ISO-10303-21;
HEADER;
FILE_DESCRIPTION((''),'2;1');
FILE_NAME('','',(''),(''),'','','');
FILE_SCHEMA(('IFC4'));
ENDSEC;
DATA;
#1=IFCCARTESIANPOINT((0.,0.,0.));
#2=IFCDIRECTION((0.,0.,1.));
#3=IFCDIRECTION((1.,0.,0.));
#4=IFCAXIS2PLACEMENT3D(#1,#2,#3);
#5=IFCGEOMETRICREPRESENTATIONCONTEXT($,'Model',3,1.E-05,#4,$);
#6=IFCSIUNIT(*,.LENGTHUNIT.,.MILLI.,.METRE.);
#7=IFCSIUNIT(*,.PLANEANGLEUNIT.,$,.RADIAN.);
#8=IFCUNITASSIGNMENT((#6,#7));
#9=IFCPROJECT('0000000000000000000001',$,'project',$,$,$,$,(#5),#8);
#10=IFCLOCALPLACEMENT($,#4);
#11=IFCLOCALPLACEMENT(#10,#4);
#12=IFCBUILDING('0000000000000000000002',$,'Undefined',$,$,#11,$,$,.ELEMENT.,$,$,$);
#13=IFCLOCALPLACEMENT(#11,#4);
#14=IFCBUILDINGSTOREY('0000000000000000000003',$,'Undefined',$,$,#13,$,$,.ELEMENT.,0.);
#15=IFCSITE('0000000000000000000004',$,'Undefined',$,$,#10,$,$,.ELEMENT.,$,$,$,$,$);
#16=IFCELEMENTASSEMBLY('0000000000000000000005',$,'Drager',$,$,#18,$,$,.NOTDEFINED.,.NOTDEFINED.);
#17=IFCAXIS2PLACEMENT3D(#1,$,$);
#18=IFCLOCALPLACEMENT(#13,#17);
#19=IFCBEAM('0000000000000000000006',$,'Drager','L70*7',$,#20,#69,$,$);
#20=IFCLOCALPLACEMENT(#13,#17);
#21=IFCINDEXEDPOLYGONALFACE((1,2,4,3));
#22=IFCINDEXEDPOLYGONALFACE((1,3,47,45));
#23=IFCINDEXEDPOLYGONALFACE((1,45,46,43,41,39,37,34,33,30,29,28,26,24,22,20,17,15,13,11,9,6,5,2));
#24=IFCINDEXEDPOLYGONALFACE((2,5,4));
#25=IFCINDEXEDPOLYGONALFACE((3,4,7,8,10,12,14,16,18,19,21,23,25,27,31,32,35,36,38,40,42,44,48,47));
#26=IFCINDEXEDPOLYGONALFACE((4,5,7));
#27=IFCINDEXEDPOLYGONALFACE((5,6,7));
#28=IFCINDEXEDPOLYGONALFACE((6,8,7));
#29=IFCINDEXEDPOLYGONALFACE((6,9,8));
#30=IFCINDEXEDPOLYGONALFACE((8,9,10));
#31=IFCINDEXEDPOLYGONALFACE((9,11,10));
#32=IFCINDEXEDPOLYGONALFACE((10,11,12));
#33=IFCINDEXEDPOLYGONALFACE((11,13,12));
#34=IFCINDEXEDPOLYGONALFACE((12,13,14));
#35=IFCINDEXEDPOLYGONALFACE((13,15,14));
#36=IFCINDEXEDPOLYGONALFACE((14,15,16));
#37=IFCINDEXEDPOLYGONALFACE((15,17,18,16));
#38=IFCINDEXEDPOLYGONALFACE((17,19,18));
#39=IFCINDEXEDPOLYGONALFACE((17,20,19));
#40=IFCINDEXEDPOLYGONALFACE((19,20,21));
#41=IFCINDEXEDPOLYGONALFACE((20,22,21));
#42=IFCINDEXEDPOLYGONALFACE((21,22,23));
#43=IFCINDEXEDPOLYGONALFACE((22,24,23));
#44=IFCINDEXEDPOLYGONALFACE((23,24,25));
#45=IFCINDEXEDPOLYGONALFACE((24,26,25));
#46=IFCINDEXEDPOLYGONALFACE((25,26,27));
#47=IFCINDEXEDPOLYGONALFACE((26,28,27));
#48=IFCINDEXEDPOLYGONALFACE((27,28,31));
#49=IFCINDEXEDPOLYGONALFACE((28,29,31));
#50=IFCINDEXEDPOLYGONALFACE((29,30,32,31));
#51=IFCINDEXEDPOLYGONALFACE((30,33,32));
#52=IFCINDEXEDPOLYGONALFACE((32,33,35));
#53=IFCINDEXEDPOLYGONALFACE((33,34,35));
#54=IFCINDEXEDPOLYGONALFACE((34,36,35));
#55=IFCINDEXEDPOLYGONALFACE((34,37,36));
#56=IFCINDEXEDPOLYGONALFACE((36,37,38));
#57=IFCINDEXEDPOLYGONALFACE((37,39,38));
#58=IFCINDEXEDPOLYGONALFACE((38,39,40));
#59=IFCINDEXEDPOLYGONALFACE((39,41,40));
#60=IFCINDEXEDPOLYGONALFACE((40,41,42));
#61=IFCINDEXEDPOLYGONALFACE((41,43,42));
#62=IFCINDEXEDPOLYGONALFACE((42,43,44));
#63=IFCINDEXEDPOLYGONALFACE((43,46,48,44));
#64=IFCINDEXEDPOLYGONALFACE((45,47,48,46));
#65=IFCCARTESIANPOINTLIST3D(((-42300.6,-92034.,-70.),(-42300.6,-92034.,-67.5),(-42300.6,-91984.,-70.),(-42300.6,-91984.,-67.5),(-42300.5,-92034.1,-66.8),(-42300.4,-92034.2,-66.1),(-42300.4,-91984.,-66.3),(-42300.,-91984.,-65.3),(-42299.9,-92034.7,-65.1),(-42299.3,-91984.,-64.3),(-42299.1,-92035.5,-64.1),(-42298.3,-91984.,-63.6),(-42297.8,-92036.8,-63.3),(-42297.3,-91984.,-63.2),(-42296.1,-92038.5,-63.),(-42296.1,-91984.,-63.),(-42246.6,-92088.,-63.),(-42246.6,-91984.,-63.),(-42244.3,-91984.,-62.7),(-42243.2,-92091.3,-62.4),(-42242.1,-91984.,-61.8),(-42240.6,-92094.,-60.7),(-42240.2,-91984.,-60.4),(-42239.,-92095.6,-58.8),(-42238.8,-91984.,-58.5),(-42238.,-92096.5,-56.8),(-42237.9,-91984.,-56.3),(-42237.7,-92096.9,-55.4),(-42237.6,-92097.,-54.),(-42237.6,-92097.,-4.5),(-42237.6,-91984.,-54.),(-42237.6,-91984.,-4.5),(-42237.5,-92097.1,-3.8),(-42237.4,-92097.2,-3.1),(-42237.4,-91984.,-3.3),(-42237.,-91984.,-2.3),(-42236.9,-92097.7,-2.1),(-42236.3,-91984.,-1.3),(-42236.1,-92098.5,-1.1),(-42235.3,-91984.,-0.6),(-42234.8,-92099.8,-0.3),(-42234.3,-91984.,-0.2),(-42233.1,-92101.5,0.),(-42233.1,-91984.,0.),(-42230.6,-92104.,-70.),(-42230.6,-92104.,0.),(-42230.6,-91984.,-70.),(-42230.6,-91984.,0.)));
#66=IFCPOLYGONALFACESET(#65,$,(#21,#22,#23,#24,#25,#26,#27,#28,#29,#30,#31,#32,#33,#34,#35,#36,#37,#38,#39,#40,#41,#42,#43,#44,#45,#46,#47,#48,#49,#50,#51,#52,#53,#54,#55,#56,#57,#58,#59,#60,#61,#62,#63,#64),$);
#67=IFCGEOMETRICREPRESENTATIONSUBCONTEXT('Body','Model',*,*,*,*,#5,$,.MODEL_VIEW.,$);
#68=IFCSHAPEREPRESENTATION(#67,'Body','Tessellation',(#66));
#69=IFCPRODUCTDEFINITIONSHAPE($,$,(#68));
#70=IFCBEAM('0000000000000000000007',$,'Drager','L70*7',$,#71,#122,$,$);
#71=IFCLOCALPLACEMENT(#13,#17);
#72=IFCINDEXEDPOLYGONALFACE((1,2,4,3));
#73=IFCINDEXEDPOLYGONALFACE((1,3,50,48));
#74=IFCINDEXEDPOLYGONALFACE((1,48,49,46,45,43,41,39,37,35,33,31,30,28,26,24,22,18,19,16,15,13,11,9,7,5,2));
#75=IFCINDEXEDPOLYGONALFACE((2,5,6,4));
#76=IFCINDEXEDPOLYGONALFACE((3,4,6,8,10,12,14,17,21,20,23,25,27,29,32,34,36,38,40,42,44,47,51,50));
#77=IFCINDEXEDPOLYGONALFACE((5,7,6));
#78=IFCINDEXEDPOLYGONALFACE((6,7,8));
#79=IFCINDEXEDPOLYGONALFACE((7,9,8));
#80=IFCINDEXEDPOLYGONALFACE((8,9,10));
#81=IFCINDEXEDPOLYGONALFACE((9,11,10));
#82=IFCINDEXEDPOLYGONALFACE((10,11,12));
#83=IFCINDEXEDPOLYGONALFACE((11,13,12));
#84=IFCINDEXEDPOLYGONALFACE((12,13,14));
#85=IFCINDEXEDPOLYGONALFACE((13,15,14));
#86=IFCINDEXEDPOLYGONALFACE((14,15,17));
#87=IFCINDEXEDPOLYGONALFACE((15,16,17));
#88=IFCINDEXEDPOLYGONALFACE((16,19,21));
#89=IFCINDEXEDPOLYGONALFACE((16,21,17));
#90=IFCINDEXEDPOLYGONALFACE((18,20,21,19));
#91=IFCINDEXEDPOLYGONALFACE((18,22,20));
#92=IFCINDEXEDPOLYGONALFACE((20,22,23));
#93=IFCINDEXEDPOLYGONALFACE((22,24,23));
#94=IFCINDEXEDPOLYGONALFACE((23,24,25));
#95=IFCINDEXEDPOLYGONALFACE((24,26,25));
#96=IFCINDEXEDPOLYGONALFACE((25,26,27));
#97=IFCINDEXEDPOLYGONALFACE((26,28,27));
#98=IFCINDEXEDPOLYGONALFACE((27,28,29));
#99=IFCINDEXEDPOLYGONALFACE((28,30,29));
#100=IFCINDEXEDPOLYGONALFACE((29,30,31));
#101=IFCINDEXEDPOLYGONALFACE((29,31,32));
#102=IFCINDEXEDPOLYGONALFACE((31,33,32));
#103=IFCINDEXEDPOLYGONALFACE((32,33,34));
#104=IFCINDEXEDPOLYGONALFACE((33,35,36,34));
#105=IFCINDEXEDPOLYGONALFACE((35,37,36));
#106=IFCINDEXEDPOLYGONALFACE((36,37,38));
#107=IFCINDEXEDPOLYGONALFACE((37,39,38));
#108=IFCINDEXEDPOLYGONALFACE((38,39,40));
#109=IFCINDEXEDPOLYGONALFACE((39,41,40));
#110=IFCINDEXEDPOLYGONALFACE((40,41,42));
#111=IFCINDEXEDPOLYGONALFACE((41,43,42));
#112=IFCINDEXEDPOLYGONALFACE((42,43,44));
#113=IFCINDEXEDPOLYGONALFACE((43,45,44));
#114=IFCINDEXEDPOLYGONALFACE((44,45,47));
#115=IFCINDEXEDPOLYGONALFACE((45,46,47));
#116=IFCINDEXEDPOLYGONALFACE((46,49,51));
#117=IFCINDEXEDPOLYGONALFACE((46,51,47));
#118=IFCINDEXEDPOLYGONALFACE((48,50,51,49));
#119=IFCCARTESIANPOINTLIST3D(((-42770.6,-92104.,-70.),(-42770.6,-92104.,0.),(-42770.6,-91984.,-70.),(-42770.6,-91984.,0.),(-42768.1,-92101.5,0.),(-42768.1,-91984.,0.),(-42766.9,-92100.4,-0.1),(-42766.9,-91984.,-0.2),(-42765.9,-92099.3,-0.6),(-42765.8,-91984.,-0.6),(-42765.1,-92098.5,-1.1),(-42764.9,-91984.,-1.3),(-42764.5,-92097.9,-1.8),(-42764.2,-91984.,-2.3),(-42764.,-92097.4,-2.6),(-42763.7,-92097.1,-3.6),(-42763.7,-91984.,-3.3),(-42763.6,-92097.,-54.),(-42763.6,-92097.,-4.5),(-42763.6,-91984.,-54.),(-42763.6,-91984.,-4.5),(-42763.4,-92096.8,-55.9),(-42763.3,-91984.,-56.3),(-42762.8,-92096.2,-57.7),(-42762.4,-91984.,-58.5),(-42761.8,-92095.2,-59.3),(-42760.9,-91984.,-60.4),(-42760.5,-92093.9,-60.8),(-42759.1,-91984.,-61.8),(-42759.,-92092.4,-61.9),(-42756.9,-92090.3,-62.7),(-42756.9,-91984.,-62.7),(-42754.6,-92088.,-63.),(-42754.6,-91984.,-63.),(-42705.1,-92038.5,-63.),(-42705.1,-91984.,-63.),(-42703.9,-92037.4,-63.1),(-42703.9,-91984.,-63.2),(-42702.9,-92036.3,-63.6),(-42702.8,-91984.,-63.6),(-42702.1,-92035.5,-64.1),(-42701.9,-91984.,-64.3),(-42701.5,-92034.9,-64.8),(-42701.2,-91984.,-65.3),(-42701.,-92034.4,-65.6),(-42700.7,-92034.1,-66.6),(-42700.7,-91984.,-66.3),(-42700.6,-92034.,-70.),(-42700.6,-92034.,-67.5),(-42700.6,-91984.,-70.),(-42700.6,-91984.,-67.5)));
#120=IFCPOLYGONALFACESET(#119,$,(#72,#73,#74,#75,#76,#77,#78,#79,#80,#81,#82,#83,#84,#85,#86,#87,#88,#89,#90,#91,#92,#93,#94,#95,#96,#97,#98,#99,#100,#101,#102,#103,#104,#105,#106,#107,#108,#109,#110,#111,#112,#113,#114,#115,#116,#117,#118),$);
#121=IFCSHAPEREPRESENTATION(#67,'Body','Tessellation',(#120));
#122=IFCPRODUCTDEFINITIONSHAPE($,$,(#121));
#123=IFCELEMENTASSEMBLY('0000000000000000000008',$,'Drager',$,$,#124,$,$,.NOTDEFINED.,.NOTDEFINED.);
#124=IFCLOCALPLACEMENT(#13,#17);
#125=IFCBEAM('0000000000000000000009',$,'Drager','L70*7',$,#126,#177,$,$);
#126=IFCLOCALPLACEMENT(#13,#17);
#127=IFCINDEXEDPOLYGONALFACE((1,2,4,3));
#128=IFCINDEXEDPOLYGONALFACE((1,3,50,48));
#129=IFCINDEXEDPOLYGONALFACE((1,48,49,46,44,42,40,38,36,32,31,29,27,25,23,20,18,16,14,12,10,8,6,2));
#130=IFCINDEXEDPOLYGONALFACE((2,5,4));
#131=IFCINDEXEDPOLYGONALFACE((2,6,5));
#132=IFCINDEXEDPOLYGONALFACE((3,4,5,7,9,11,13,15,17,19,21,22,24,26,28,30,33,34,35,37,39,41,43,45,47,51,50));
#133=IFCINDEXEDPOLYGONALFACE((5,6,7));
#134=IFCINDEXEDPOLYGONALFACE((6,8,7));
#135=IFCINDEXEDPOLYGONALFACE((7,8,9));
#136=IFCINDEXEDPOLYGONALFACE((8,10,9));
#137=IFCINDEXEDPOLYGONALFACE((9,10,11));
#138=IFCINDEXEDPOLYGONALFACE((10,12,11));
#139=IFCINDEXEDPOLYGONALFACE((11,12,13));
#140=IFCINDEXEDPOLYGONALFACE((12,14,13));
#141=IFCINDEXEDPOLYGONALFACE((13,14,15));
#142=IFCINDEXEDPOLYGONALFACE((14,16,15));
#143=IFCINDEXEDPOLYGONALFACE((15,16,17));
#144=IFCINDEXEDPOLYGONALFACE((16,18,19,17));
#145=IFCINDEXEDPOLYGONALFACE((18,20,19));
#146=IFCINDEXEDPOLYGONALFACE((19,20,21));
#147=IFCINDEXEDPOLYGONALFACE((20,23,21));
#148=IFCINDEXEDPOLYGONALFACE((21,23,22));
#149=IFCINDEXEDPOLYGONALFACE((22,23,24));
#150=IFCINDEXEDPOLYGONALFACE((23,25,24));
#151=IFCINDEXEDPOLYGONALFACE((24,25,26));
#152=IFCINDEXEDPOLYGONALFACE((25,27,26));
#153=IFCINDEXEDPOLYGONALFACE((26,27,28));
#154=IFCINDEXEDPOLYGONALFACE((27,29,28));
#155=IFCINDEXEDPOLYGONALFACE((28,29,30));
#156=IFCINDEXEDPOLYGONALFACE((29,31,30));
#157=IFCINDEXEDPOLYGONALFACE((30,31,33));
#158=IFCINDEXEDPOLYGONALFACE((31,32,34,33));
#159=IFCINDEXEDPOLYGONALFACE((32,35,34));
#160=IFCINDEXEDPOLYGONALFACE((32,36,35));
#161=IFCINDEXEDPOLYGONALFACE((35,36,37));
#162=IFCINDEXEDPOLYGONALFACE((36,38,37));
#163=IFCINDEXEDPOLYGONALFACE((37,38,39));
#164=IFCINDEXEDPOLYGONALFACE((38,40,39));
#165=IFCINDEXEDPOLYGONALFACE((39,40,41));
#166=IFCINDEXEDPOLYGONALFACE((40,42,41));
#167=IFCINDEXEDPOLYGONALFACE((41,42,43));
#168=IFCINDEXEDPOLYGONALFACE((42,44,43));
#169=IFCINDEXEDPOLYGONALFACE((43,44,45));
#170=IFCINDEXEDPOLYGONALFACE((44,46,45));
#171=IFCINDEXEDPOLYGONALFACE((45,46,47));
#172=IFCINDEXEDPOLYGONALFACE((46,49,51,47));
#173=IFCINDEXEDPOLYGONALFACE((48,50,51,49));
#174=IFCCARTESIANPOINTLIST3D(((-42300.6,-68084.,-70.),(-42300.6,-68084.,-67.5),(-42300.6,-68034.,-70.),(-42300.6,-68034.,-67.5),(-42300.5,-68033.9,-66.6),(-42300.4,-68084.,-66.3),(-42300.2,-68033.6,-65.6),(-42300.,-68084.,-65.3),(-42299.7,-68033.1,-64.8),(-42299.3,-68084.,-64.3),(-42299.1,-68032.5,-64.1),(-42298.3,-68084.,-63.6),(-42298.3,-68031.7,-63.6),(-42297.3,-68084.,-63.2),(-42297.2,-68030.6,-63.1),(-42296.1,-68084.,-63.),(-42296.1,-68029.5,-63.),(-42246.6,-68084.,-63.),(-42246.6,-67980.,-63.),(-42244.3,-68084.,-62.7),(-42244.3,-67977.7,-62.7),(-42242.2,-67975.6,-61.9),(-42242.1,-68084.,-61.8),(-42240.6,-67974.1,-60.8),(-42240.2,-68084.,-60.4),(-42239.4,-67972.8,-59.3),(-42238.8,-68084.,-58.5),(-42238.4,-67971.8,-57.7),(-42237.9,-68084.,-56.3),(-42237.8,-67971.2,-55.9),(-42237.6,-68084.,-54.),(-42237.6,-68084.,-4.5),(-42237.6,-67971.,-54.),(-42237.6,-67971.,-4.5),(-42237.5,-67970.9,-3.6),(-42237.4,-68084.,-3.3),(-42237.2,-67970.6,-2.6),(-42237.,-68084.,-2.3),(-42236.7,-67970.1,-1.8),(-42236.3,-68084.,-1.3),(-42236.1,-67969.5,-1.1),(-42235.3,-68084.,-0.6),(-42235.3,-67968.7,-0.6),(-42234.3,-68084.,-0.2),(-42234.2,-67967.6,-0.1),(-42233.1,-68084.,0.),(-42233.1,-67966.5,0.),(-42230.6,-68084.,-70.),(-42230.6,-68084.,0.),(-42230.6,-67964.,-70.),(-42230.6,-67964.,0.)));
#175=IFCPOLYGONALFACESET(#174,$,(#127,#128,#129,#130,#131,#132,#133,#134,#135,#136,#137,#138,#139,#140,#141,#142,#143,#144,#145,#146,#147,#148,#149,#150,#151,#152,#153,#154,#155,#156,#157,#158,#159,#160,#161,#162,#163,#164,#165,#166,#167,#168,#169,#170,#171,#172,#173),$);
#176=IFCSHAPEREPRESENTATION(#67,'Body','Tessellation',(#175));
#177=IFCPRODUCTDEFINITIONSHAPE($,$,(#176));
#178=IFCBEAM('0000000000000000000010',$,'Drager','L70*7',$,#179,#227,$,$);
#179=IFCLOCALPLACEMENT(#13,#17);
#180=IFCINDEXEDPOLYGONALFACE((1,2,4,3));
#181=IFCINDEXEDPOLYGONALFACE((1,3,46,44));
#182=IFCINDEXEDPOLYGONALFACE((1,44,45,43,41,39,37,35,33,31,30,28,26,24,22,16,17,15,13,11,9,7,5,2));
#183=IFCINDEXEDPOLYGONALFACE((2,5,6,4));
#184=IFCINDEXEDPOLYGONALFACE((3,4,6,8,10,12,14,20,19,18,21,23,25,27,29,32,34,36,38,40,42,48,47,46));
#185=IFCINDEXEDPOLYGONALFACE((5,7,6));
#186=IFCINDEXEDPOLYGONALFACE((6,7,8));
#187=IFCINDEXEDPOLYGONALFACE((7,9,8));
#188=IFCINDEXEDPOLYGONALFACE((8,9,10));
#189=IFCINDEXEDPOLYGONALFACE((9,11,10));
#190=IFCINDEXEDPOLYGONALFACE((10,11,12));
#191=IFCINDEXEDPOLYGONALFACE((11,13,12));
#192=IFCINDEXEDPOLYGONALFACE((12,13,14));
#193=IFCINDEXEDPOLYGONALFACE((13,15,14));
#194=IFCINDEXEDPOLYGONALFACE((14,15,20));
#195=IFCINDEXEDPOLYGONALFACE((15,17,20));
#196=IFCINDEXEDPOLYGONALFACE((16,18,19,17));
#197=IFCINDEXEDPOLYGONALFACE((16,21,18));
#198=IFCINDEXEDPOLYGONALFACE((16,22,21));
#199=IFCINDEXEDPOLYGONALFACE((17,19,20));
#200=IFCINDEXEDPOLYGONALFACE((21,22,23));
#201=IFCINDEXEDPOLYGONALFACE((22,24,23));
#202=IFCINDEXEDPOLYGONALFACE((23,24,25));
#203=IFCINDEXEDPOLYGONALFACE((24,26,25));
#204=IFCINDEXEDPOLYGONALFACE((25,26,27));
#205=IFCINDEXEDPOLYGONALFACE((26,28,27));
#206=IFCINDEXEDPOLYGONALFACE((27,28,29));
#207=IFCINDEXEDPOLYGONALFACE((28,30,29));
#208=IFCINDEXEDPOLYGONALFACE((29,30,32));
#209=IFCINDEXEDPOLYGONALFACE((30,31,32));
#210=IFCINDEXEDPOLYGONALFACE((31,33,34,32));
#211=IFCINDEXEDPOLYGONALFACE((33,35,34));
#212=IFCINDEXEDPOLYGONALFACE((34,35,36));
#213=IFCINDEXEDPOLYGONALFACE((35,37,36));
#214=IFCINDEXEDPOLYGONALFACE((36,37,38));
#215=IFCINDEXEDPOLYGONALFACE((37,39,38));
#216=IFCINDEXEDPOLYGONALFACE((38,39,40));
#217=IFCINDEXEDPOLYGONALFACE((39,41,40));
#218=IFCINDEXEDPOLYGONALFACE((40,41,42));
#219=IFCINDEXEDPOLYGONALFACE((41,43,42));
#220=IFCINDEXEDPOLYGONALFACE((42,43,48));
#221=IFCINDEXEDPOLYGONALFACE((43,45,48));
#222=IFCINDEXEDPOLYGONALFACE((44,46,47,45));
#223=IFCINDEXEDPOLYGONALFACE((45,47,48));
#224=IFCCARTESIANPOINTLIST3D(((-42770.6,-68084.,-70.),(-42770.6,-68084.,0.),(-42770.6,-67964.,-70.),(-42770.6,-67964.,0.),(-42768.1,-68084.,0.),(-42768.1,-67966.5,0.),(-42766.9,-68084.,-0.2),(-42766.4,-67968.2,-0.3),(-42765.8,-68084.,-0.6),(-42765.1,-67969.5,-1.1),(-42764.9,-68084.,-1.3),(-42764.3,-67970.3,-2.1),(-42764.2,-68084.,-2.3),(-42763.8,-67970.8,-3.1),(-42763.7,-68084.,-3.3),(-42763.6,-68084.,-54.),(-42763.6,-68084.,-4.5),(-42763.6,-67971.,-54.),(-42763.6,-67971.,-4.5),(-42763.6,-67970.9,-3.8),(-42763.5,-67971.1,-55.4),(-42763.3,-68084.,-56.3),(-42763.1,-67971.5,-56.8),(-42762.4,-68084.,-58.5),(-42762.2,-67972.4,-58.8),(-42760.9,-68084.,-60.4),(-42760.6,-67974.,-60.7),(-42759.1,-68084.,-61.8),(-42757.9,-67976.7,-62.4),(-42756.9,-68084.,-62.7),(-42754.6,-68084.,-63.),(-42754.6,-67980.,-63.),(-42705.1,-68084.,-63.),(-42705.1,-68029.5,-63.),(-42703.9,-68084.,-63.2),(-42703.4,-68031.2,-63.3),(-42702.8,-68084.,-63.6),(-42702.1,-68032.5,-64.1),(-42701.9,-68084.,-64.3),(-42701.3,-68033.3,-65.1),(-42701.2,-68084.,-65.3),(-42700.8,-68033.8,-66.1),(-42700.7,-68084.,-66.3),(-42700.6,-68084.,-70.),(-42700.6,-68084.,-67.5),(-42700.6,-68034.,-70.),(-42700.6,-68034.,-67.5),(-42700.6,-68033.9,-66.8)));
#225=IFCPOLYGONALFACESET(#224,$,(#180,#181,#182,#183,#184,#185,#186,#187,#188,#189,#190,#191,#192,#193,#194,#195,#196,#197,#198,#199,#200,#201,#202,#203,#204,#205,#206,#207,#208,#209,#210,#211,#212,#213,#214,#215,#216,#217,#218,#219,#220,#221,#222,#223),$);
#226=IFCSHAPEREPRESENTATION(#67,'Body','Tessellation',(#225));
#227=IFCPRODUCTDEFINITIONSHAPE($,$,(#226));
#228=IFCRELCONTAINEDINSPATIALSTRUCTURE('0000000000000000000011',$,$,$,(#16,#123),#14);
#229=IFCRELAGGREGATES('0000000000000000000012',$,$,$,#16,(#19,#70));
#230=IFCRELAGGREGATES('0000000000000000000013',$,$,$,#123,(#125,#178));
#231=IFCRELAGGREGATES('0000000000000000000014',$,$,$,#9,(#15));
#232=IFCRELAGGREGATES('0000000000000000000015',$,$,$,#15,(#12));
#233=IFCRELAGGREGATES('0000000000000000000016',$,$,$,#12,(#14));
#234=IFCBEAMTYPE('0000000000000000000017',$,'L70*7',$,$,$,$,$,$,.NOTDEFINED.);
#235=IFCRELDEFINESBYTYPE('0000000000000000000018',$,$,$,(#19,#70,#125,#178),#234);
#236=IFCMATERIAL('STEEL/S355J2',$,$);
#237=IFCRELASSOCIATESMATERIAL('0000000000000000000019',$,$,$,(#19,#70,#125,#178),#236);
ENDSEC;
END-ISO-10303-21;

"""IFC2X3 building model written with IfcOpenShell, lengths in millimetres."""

from ifc_helpers import new_model, si_unit, frame, origin_with_axes, origin_2d_with_axis, place, context, subcontext, project, spatial, l_section, extrude, clip, halfspace, material, type_object, element, aggregate, save


model = new_model("IFC2X3")

# Units and contexts
model_context = context("Model", 3, precision=1e-05, world=origin_with_axes())
body_context = subcontext(model_context, "Body", "Model", "MODEL_VIEW")
ifc_project = project(units=[si_unit("LENGTHUNIT", "METRE", prefix="MILLI"), si_unit("PLANEANGLEUNIT", "RADIAN")], contexts=[model_context])

# Site, building, storey
site_placement = place(None, origin_with_axes())
site = spatial("IfcSite", under=ifc_project, at=site_placement, Name="Undefined", CompositionType="ELEMENT")
building_placement = place(site_placement, origin_with_axes())
building = spatial("IfcBuilding", under=site, at=building_placement, Name="Undefined", CompositionType="ELEMENT")
storey_placement = place(building_placement, origin_with_axes())
storey = spatial("IfcBuildingStorey", under=building, at=storey_placement, Name="Undefined", CompositionType="ELEMENT", Elevation=0.0)

# Element assemblies, beams
assembly_1_placement = place(storey_placement, origin_with_axes())
assembly_1 = element("IfcElementAssembly", 1, at=assembly_1_placement, inside=storey, Name="Drager", AssemblyPlace="NOTDEFINED", PredefinedType="NOTDEFINED")
ifc_material_1 = material(Name="STEEL/S355J2")
beam_type_1 = type_object("IfcBeamType", Name="L70*7", PredefinedType="NOTDEFINED")
beam_1_placement = place(assembly_1_placement, frame((-42265.6, -91984.0, -35.0), z_axis=(0.0, 0.0, 1.0), x_axis=(0.0, -1.0, 0.0)))
beam_1 = element("IfcBeam", 2, at=beam_1_placement, type_object=beam_type_1, material=ifc_material_1, Name="Drager", Description="L70*7", context=body_context, shape_type="Clipping", body=[
    clip(extrude(l_section(Depth=70.0, Width=70.0, Thickness=7.0, FilletRadius=9.0, EdgeRadius=4.5, at=origin_2d_with_axis()), frame((120.3, 0.0, 0.0), z_axis=(-1.0, 0.0, 0.0), x_axis=(0.0, -1.0, 0.0)), (0.0, 0.0, 1.0), 120.3), halfspace(frame((50.0, -35.0, 35.0), z_axis=(0.707107, -0.707107, 0.0), x_axis=(0.0, 0.0, 1.0)), False)),
])
beam_2_placement = place(assembly_1_placement, frame((-42735.6, -92034.0, -35.0), z_axis=(0.0, 0.0, 1.0), x_axis=(0.0, 1.0, 0.0)))
beam_2 = element("IfcBeam", 3, at=beam_2_placement, type_object=beam_type_1, material=ifc_material_1, Name="Drager", Description="L70*7", context=body_context, shape_type="Clipping", body=[
    clip(extrude(l_section(Depth=70.0, Width=70.0, Thickness=7.0, FilletRadius=9.0, EdgeRadius=4.5, at=origin_2d_with_axis()), frame((50.0, 0.0, 0.0), z_axis=(-1.0, 0.0, 0.0), x_axis=(0.0, -1.0, 0.0)), (0.0, 0.0, 1.0), 120.3), halfspace(frame((0.0, -35.0, 35.0), z_axis=(-0.707107, -0.707107, 0.0), x_axis=(-0.707107, 0.707107, 0.0)), False)),
])
assembly_2_placement = place(storey_placement, origin_with_axes())
assembly_2 = element("IfcElementAssembly", 4, at=assembly_2_placement, inside=storey, Name="Drager", AssemblyPlace="NOTDEFINED", PredefinedType="NOTDEFINED")
beam_3_placement = place(assembly_2_placement, frame((-42265.6, -68034.0, -35.0), z_axis=(0.0, 0.0, 1.0), x_axis=(0.0, -1.0, 0.0)))
beam_3 = element("IfcBeam", 5, at=beam_3_placement, type_object=beam_type_1, material=ifc_material_1, Name="Drager", Description="L70*7", context=body_context, shape_type="Clipping", body=[
    clip(extrude(l_section(Depth=70.0, Width=70.0, Thickness=7.0, FilletRadius=9.0, EdgeRadius=4.5, at=origin_2d_with_axis()), frame((50.0, 0.0, 0.0), z_axis=(-1.0, 0.0, 0.0), x_axis=(0.0, -1.0, 0.0)), (0.0, 0.0, 1.0), 120.3), halfspace(frame((0.0, -35.0, 35.0), z_axis=(-0.707107, -0.707107, 0.0), x_axis=(-0.707107, 0.707107, 0.0)), False)),
])
beam_4_placement = place(assembly_2_placement, frame((-42735.6, -68084.0, -35.0), z_axis=(0.0, 0.0, 1.0), x_axis=(0.0, 1.0, 0.0)))
beam_4 = element("IfcBeam", 6, at=beam_4_placement, type_object=beam_type_1, material=ifc_material_1, Name="Drager", Description="L70*7", context=body_context, shape_type="Clipping", body=[
    clip(extrude(l_section(Depth=70.0, Width=70.0, Thickness=7.0, FilletRadius=9.0, EdgeRadius=4.5, at=origin_2d_with_axis()), frame((120.3, 0.0, 0.0), z_axis=(-1.0, 0.0, 0.0), x_axis=(0.0, -1.0, 0.0)), (0.0, 0.0, 1.0), 120.3), halfspace(frame((50.0, -35.0, 35.0), z_axis=(0.707107, -0.707107, 0.0), x_axis=(0.0, 0.0, 1.0)), False)),
])

aggregate(assembly_1, [beam_1, beam_2])

aggregate(assembly_2, [beam_3, beam_4])

save(model, "model.ifc")
